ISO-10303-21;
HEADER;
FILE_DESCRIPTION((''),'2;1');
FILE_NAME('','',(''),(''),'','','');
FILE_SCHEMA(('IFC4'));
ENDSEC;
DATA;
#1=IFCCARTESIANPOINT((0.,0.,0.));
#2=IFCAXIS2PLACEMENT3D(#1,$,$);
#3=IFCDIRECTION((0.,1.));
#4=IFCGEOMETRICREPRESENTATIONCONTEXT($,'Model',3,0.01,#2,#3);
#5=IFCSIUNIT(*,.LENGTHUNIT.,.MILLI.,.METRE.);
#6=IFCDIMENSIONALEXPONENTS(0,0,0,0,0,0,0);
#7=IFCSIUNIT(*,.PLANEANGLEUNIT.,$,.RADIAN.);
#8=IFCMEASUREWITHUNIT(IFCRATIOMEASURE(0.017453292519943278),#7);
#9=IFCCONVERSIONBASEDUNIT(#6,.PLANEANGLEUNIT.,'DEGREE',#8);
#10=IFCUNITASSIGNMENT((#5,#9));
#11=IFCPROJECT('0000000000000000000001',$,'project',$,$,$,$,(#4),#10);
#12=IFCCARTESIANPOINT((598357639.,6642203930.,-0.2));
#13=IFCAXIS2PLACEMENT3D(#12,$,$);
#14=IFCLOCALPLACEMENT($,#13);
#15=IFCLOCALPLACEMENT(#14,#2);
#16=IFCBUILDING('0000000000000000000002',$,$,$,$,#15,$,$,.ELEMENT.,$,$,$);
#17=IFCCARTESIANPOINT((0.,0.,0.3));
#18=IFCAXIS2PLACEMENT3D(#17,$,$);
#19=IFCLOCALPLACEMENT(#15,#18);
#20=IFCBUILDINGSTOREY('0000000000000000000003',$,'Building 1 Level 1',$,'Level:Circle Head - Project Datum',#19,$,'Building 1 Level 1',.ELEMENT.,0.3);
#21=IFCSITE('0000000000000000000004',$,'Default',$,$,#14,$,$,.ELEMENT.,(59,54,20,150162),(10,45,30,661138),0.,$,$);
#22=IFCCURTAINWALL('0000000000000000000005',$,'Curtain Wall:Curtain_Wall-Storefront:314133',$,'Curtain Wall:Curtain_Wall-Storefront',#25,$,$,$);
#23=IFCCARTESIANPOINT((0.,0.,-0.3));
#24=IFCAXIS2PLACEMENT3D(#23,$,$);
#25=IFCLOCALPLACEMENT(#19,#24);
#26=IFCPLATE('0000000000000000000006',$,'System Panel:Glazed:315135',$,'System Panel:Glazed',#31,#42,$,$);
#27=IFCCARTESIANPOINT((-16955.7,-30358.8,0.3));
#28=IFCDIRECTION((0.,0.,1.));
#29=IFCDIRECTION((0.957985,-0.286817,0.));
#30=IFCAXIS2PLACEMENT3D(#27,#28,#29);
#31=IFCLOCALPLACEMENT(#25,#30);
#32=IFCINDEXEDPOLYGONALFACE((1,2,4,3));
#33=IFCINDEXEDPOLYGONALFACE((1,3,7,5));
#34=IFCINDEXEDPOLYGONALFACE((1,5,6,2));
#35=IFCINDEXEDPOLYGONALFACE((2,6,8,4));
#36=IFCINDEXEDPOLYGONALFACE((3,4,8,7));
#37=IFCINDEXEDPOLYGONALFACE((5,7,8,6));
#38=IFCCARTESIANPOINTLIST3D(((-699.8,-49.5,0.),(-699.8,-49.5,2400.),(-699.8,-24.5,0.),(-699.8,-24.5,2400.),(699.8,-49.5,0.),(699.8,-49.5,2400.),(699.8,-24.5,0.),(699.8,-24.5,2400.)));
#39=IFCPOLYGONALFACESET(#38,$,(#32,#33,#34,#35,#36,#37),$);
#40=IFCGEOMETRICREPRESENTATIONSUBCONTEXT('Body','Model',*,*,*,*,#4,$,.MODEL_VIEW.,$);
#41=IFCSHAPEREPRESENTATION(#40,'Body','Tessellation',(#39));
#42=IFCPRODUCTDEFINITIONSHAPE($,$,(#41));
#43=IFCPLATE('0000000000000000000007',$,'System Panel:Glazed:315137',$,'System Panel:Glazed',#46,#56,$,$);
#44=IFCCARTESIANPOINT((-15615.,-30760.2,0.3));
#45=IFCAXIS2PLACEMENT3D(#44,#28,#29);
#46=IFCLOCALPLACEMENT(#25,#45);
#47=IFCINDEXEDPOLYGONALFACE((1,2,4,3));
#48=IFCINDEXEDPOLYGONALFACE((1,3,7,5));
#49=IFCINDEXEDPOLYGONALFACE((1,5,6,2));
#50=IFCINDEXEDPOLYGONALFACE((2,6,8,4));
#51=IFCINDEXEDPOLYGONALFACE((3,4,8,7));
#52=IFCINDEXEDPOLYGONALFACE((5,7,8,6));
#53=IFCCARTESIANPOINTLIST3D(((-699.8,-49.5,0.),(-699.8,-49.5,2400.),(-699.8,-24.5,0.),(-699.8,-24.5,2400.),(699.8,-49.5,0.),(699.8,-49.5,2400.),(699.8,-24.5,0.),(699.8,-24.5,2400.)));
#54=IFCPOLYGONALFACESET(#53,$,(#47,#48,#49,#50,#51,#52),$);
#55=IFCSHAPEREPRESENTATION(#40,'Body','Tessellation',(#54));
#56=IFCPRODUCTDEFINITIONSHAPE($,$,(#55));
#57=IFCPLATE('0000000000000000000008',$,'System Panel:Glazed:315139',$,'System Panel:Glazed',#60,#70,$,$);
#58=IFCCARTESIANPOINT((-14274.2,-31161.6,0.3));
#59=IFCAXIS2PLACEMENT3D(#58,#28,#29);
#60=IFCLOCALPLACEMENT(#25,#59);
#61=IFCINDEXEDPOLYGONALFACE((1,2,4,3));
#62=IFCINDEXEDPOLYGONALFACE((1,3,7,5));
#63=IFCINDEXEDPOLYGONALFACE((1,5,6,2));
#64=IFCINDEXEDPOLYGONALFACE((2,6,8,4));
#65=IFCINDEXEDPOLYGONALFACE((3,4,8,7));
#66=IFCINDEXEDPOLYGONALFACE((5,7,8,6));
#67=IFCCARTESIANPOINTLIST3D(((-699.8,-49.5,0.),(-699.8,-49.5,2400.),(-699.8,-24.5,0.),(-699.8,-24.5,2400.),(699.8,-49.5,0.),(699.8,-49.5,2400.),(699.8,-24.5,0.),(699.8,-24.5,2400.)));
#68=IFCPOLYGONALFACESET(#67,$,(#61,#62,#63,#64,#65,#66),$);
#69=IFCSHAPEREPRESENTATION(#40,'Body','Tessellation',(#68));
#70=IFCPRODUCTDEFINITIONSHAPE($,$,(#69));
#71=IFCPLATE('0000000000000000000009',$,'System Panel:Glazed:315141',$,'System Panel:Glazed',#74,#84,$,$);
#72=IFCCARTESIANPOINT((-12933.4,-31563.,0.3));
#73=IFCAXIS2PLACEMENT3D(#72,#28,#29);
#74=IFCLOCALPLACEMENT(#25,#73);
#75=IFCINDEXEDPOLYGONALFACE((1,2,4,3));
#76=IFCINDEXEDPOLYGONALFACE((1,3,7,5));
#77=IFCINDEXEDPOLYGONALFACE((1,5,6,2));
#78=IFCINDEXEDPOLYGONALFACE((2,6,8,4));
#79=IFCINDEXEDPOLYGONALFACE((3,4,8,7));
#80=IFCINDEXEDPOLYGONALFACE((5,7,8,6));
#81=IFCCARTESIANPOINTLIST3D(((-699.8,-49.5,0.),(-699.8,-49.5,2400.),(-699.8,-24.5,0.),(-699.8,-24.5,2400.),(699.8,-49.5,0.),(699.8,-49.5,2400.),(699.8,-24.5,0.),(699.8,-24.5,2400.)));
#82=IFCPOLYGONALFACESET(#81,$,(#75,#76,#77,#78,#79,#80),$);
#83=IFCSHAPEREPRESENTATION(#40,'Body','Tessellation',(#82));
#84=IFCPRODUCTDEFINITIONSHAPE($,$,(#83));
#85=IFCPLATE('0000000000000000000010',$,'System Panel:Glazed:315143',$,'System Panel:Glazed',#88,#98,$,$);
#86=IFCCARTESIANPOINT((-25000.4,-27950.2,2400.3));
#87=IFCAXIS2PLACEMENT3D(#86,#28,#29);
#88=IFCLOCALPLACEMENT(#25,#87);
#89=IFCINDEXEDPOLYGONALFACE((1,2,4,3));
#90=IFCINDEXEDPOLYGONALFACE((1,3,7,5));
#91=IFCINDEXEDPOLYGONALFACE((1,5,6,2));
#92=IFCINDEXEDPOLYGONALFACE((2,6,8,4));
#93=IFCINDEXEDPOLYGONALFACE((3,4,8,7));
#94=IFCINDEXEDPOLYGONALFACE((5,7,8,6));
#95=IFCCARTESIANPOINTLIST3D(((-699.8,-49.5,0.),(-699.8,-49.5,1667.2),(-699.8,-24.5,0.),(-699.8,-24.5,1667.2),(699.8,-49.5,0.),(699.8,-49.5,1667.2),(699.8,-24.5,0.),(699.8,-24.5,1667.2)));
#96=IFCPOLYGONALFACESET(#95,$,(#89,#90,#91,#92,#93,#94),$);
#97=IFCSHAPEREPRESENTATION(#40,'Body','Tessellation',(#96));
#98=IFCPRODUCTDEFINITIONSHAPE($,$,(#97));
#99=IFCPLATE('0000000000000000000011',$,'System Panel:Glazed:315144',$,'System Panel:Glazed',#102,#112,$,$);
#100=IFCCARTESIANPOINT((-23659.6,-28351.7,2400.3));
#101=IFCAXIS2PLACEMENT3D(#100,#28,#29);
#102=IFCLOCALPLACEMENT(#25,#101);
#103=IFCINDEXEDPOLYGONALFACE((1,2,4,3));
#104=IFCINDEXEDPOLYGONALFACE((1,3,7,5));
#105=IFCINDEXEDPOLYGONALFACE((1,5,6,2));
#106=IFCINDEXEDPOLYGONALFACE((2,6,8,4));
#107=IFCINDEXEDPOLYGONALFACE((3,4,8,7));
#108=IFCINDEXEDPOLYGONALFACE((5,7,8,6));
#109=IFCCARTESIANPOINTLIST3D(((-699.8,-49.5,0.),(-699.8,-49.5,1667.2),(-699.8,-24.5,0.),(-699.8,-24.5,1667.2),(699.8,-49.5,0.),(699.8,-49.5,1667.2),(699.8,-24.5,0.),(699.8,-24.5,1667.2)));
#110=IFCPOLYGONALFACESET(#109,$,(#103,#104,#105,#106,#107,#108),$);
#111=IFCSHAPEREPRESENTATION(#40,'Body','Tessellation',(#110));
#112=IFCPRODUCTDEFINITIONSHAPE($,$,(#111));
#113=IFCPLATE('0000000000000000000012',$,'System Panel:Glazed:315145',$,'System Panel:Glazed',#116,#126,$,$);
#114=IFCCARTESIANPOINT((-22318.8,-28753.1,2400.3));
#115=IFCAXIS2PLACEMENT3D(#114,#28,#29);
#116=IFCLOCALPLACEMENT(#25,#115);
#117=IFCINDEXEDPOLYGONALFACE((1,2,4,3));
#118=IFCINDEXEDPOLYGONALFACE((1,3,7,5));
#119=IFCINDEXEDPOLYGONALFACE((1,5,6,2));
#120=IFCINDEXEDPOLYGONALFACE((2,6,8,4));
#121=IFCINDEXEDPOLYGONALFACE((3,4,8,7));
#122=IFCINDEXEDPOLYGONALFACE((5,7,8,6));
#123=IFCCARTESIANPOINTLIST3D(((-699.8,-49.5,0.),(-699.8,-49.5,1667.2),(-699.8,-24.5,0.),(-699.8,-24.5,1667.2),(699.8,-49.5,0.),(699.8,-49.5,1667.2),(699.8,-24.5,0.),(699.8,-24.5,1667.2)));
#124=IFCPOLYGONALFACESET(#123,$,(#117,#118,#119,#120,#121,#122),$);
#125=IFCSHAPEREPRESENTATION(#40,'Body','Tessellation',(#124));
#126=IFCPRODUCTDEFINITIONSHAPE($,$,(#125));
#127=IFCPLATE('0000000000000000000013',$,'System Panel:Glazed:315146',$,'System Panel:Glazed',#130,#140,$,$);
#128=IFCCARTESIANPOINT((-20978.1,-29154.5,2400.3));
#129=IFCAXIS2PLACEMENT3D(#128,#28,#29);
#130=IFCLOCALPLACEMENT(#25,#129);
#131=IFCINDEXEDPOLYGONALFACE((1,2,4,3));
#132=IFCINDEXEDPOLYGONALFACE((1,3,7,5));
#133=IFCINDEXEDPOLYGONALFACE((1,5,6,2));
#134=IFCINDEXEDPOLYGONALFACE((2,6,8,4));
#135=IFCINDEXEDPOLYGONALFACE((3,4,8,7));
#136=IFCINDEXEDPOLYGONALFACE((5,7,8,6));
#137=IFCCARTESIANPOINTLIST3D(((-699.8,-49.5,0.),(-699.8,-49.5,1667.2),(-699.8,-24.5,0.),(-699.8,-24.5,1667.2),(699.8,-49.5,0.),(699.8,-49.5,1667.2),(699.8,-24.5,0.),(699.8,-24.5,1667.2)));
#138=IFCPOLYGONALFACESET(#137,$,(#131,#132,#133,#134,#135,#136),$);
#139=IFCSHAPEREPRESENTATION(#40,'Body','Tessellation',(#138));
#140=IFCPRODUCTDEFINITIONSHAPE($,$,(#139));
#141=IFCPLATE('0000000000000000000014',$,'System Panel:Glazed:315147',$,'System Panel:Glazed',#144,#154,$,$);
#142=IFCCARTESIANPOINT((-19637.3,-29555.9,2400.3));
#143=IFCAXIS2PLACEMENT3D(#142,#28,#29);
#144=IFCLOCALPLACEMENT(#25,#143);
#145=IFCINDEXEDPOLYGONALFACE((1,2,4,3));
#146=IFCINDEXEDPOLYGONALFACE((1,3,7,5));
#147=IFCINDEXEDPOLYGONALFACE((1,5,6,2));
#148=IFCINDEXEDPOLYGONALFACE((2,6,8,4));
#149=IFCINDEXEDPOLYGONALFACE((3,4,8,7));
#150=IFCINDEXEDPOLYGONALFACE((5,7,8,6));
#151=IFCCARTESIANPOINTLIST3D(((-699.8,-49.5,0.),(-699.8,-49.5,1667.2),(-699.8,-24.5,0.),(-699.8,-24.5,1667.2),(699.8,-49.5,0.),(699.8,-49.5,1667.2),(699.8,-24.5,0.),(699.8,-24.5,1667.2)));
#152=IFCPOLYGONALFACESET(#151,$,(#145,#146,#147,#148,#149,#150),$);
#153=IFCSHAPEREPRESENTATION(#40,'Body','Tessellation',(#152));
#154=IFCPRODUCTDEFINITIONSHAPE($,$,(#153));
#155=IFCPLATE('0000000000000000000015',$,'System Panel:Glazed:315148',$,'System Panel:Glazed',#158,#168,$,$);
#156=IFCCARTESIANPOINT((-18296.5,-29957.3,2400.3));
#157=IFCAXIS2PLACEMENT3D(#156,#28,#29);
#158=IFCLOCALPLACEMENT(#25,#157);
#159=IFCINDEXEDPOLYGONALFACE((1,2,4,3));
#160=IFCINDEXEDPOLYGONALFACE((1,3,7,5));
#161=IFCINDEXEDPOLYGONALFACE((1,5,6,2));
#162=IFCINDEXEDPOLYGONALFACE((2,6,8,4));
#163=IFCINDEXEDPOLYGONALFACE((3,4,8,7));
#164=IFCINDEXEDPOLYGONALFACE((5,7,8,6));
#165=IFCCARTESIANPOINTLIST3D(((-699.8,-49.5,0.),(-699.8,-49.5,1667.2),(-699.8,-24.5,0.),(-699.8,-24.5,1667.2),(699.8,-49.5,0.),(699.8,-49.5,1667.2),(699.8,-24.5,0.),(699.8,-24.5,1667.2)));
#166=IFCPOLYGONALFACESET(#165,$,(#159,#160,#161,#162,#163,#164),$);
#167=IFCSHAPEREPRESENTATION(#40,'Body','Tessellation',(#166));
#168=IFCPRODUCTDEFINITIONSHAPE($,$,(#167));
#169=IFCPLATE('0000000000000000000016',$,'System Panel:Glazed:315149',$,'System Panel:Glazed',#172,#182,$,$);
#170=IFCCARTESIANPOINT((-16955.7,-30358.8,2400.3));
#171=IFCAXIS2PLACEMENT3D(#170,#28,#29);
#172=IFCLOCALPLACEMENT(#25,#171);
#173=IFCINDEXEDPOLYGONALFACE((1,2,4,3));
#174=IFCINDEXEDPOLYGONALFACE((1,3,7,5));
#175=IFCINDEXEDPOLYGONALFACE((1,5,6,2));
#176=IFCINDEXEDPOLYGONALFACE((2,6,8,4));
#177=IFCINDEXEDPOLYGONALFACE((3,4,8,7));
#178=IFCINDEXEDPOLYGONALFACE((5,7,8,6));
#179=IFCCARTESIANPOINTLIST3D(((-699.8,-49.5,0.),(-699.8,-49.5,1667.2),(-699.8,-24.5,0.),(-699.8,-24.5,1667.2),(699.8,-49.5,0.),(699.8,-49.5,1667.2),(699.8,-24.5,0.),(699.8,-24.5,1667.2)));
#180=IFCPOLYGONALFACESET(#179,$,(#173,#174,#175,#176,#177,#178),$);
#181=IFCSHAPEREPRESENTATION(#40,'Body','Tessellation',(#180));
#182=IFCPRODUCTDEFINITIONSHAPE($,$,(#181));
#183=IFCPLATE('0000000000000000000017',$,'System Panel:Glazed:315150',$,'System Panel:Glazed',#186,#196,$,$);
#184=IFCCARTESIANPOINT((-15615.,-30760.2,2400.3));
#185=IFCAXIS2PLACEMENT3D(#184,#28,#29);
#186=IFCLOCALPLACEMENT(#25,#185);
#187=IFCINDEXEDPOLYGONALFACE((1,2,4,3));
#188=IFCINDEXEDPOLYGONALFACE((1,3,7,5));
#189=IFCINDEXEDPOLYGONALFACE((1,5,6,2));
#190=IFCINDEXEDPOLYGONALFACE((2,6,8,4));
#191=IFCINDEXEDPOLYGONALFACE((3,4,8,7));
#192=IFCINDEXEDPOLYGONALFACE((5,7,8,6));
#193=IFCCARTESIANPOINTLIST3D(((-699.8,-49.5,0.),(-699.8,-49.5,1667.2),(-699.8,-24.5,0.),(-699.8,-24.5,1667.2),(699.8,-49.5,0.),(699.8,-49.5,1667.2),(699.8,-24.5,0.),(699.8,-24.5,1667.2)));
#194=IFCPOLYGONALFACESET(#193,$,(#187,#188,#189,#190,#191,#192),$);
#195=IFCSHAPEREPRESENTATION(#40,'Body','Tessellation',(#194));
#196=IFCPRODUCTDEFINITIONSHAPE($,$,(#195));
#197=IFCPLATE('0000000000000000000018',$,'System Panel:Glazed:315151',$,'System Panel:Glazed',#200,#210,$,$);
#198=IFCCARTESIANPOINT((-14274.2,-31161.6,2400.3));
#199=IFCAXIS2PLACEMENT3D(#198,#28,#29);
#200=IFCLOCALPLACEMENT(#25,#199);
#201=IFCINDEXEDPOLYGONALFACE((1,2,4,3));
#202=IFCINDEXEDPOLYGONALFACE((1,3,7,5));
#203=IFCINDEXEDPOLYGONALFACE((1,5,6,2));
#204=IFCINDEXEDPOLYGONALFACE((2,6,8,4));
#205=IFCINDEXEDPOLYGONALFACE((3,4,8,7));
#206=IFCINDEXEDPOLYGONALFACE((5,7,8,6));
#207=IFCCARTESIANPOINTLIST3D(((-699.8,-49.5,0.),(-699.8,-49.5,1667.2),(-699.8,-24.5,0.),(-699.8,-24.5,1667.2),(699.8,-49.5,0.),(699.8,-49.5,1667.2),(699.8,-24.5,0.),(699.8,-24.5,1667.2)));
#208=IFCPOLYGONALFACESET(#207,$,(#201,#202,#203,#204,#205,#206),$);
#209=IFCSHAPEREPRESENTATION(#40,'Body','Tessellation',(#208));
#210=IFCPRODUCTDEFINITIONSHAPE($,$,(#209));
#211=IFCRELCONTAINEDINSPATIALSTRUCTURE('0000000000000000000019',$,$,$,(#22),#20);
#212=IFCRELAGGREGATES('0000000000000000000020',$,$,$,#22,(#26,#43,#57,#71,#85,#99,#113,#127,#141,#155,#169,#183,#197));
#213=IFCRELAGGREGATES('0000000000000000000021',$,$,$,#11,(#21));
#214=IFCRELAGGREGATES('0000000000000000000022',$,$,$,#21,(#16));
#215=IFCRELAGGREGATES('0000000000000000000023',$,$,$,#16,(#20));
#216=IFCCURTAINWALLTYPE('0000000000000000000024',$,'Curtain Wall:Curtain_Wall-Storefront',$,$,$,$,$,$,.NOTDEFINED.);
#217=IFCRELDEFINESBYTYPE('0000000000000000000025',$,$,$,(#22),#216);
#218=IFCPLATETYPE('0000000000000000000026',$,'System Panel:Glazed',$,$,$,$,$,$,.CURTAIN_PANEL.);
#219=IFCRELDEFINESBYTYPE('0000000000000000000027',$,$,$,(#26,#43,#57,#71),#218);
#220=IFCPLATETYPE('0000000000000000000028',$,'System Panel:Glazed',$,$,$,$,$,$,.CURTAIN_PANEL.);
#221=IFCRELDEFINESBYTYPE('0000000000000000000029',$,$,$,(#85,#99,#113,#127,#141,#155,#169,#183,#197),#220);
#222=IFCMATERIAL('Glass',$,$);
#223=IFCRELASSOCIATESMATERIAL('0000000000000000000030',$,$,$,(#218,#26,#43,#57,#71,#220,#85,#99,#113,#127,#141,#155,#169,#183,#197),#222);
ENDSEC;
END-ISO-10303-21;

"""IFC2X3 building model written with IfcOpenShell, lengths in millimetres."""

from ifc_helpers import new_model, entity, si_unit, converted_unit, direction, frame, frame_2d, origin, place, context, subcontext, project, spatial, rectangle, extrude, source, transform, mapped, material, type_object, type_shapes, element, aggregate, save


model = new_model("IFC2X3")

# Units and contexts
model_context = context("Model", 3, precision=0.01, world=origin(), true_north=direction((0.0, 1.0)))
body_context = subcontext(model_context, "Body", "Model", "MODEL_VIEW")
ifc_project = project(units=[si_unit("LENGTHUNIT", "METRE", prefix="MILLI"), converted_unit("PLANEANGLEUNIT", "DEGREE", entity("IfcRatioMeasure", 0.017453292519943278), si_unit("PLANEANGLEUNIT", "RADIAN"), dimensions=[0, 0, 0, 0, 0, 0, 0])], contexts=[model_context])

# Site, building, storey
site_placement = place(None, frame((598357639.0, 6642203930.0, -0.2)))
site = spatial("IfcSite", under=ifc_project, at=site_placement, Name="Default", CompositionType="ELEMENT", RefLatitude=(59, 54, 20, 150162), RefLongitude=(10, 45, 30, 661138), RefElevation=0.0)
building_placement = place(site_placement, origin())
building = spatial("IfcBuilding", under=site, at=building_placement, CompositionType="ELEMENT")
storey_placement = place(building_placement, frame((0.0, 0.0, 0.3)))
storey = spatial("IfcBuildingStorey", under=building, at=storey_placement, Name="Building 1 Level 1", ObjectType="Level:Circle Head - Project Datum", LongName="Building 1 Level 1", CompositionType="ELEMENT", Elevation=0.3)

# Shared definitions
curtain_wall_type = type_object("IfcCurtainWallType", Name="Curtain Wall:Curtain_Wall-Storefront", PredefinedType="NOTDEFINED")
ifc_material = material(Name="Glass")

# Curtain wall, plates
curtain_wall_1_placement = place(storey_placement, frame((0.0, 0.0, -0.3)))
curtain_wall_1 = element("IfcCurtainWall", 1, at=curtain_wall_1_placement, inside=storey, type_object=curtain_wall_type, Name="Curtain Wall:Curtain_Wall-Storefront:314133", ObjectType="Curtain Wall:Curtain_Wall-Storefront")
plate_type_1 = type_object("IfcPlateType", Name="System Panel:Glazed", PredefinedType="CURTAIN_PANEL", material=ifc_material)
shared_shape_1 = source(origin(), body_context, "Body", "SweptSolid", [
    extrude(rectangle(XDim=25.0, YDim=1399.6, at=frame_2d((0.0, 0.0), x_axis=(1.0, 0.0))), frame((0.0, -37.0, 0.0), z_axis=(0.0, 0.0, 1.0), x_axis=(0.0, 1.0, 0.0)), (0.0, 0.0, 1.0), 2400.0),
])
type_shapes(plate_type_1, [shared_shape_1])
plate_1_placement = place(curtain_wall_1_placement, frame((-16955.7, -30358.8, 0.3), z_axis=(0.0, 0.0, 1.0), x_axis=(0.957985, -0.286817, 0.0)))
plate_1 = element("IfcPlate", 2, at=plate_1_placement, type_object=plate_type_1, material=ifc_material, Name="System Panel:Glazed:315135", ObjectType="System Panel:Glazed", context=body_context, shape_type="MappedRepresentation", body=[
    mapped(shared_shape_1, transform((0.0, 0.0, 0.0), scale=1.0)),
])
plate_2_placement = place(curtain_wall_1_placement, frame((-15615.0, -30760.2, 0.3), z_axis=(0.0, 0.0, 1.0), x_axis=(0.957985, -0.286817, 0.0)))
plate_2 = element("IfcPlate", 3, at=plate_2_placement, type_object=plate_type_1, material=ifc_material, Name="System Panel:Glazed:315137", ObjectType="System Panel:Glazed", context=body_context, shape_type="MappedRepresentation", body=[
    mapped(shared_shape_1, transform((0.0, 0.0, 0.0), scale=1.0)),
])
plate_3_placement = place(curtain_wall_1_placement, frame((-14274.2, -31161.6, 0.3), z_axis=(0.0, 0.0, 1.0), x_axis=(0.957985, -0.286817, 0.0)))
plate_3 = element("IfcPlate", 4, at=plate_3_placement, type_object=plate_type_1, material=ifc_material, Name="System Panel:Glazed:315139", ObjectType="System Panel:Glazed", context=body_context, shape_type="MappedRepresentation", body=[
    mapped(shared_shape_1, transform((0.0, 0.0, 0.0), scale=1.0)),
])
plate_4_placement = place(curtain_wall_1_placement, frame((-12933.4, -31563.0, 0.3), z_axis=(0.0, 0.0, 1.0), x_axis=(0.957985, -0.286817, 0.0)))
plate_4 = element("IfcPlate", 5, at=plate_4_placement, type_object=plate_type_1, material=ifc_material, Name="System Panel:Glazed:315141", ObjectType="System Panel:Glazed", context=body_context, shape_type="MappedRepresentation", body=[
    mapped(shared_shape_1, transform((0.0, 0.0, 0.0), scale=1.0)),
])
plate_type_2 = type_object("IfcPlateType", Name="System Panel:Glazed", PredefinedType="CURTAIN_PANEL", material=ifc_material)
shared_shape_2 = source(origin(), body_context, "Body", "SweptSolid", [
    extrude(rectangle(XDim=25.0, YDim=1399.6, at=frame_2d((0.0, 0.0), x_axis=(1.0, 0.0))), frame((0.0, -37.0, 0.0), z_axis=(0.0, 0.0, 1.0), x_axis=(0.0, 1.0, 0.0)), (0.0, 0.0, 1.0), 1667.2),
])
type_shapes(plate_type_2, [shared_shape_2])
plate_5_placement = place(curtain_wall_1_placement, frame((-25000.4, -27950.2, 2400.3), z_axis=(0.0, 0.0, 1.0), x_axis=(0.957985, -0.286817, 0.0)))
plate_5 = element("IfcPlate", 6, at=plate_5_placement, type_object=plate_type_2, material=ifc_material, Name="System Panel:Glazed:315143", ObjectType="System Panel:Glazed", context=body_context, shape_type="MappedRepresentation", body=[
    mapped(shared_shape_2, transform((0.0, 0.0, 0.0), scale=1.0)),
])
plate_6_placement = place(curtain_wall_1_placement, frame((-23659.6, -28351.7, 2400.3), z_axis=(0.0, 0.0, 1.0), x_axis=(0.957985, -0.286817, 0.0)))
plate_6 = element("IfcPlate", 7, at=plate_6_placement, type_object=plate_type_2, material=ifc_material, Name="System Panel:Glazed:315144", ObjectType="System Panel:Glazed", context=body_context, shape_type="MappedRepresentation", body=[
    mapped(shared_shape_2, transform((0.0, 0.0, 0.0), scale=1.0)),
])
plate_7_placement = place(curtain_wall_1_placement, frame((-22318.8, -28753.1, 2400.3), z_axis=(0.0, 0.0, 1.0), x_axis=(0.957985, -0.286817, 0.0)))
plate_7 = element("IfcPlate", 8, at=plate_7_placement, type_object=plate_type_2, material=ifc_material, Name="System Panel:Glazed:315145", ObjectType="System Panel:Glazed", context=body_context, shape_type="MappedRepresentation", body=[
    mapped(shared_shape_2, transform((0.0, 0.0, 0.0), scale=1.0)),
])
plate_8_placement = place(curtain_wall_1_placement, frame((-20978.1, -29154.5, 2400.3), z_axis=(0.0, 0.0, 1.0), x_axis=(0.957985, -0.286817, 0.0)))
plate_8 = element("IfcPlate", 9, at=plate_8_placement, type_object=plate_type_2, material=ifc_material, Name="System Panel:Glazed:315146", ObjectType="System Panel:Glazed", context=body_context, shape_type="MappedRepresentation", body=[
    mapped(shared_shape_2, transform((0.0, 0.0, 0.0), scale=1.0)),
])
plate_9_placement = place(curtain_wall_1_placement, frame((-19637.3, -29555.9, 2400.3), z_axis=(0.0, 0.0, 1.0), x_axis=(0.957985, -0.286817, 0.0)))
plate_9 = element("IfcPlate", 10, at=plate_9_placement, type_object=plate_type_2, material=ifc_material, Name="System Panel:Glazed:315147", ObjectType="System Panel:Glazed", context=body_context, shape_type="MappedRepresentation", body=[
    mapped(shared_shape_2, transform((0.0, 0.0, 0.0), scale=1.0)),
])
plate_10_placement = place(curtain_wall_1_placement, frame((-18296.5, -29957.3, 2400.3), z_axis=(0.0, 0.0, 1.0), x_axis=(0.957985, -0.286817, 0.0)))
plate_10 = element("IfcPlate", 11, at=plate_10_placement, type_object=plate_type_2, material=ifc_material, Name="System Panel:Glazed:315148", ObjectType="System Panel:Glazed", context=body_context, shape_type="MappedRepresentation", body=[
    mapped(shared_shape_2, transform((0.0, 0.0, 0.0), scale=1.0)),
])
plate_11_placement = place(curtain_wall_1_placement, frame((-16955.7, -30358.8, 2400.3), z_axis=(0.0, 0.0, 1.0), x_axis=(0.957985, -0.286817, 0.0)))
plate_11 = element("IfcPlate", 12, at=plate_11_placement, type_object=plate_type_2, material=ifc_material, Name="System Panel:Glazed:315149", ObjectType="System Panel:Glazed", context=body_context, shape_type="MappedRepresentation", body=[
    mapped(shared_shape_2, transform((0.0, 0.0, 0.0), scale=1.0)),
])
plate_12_placement = place(curtain_wall_1_placement, frame((-15615.0, -30760.2, 2400.3), z_axis=(0.0, 0.0, 1.0), x_axis=(0.957985, -0.286817, 0.0)))
plate_12 = element("IfcPlate", 13, at=plate_12_placement, type_object=plate_type_2, material=ifc_material, Name="System Panel:Glazed:315150", ObjectType="System Panel:Glazed", context=body_context, shape_type="MappedRepresentation", body=[
    mapped(shared_shape_2, transform((0.0, 0.0, 0.0), scale=1.0)),
])
plate_13_placement = place(curtain_wall_1_placement, frame((-14274.2, -31161.6, 2400.3), z_axis=(0.0, 0.0, 1.0), x_axis=(0.957985, -0.286817, 0.0)))
plate_13 = element("IfcPlate", 14, at=plate_13_placement, type_object=plate_type_2, material=ifc_material, Name="System Panel:Glazed:315151", ObjectType="System Panel:Glazed", context=body_context, shape_type="MappedRepresentation", body=[
    mapped(shared_shape_2, transform((0.0, 0.0, 0.0), scale=1.0)),
])
aggregate(curtain_wall_1, [plate_1, plate_2, plate_3, plate_4, plate_5, plate_6, plate_7, plate_8, plate_9, plate_10, plate_11, plate_12, plate_13])

save(model, "model.ifc")
